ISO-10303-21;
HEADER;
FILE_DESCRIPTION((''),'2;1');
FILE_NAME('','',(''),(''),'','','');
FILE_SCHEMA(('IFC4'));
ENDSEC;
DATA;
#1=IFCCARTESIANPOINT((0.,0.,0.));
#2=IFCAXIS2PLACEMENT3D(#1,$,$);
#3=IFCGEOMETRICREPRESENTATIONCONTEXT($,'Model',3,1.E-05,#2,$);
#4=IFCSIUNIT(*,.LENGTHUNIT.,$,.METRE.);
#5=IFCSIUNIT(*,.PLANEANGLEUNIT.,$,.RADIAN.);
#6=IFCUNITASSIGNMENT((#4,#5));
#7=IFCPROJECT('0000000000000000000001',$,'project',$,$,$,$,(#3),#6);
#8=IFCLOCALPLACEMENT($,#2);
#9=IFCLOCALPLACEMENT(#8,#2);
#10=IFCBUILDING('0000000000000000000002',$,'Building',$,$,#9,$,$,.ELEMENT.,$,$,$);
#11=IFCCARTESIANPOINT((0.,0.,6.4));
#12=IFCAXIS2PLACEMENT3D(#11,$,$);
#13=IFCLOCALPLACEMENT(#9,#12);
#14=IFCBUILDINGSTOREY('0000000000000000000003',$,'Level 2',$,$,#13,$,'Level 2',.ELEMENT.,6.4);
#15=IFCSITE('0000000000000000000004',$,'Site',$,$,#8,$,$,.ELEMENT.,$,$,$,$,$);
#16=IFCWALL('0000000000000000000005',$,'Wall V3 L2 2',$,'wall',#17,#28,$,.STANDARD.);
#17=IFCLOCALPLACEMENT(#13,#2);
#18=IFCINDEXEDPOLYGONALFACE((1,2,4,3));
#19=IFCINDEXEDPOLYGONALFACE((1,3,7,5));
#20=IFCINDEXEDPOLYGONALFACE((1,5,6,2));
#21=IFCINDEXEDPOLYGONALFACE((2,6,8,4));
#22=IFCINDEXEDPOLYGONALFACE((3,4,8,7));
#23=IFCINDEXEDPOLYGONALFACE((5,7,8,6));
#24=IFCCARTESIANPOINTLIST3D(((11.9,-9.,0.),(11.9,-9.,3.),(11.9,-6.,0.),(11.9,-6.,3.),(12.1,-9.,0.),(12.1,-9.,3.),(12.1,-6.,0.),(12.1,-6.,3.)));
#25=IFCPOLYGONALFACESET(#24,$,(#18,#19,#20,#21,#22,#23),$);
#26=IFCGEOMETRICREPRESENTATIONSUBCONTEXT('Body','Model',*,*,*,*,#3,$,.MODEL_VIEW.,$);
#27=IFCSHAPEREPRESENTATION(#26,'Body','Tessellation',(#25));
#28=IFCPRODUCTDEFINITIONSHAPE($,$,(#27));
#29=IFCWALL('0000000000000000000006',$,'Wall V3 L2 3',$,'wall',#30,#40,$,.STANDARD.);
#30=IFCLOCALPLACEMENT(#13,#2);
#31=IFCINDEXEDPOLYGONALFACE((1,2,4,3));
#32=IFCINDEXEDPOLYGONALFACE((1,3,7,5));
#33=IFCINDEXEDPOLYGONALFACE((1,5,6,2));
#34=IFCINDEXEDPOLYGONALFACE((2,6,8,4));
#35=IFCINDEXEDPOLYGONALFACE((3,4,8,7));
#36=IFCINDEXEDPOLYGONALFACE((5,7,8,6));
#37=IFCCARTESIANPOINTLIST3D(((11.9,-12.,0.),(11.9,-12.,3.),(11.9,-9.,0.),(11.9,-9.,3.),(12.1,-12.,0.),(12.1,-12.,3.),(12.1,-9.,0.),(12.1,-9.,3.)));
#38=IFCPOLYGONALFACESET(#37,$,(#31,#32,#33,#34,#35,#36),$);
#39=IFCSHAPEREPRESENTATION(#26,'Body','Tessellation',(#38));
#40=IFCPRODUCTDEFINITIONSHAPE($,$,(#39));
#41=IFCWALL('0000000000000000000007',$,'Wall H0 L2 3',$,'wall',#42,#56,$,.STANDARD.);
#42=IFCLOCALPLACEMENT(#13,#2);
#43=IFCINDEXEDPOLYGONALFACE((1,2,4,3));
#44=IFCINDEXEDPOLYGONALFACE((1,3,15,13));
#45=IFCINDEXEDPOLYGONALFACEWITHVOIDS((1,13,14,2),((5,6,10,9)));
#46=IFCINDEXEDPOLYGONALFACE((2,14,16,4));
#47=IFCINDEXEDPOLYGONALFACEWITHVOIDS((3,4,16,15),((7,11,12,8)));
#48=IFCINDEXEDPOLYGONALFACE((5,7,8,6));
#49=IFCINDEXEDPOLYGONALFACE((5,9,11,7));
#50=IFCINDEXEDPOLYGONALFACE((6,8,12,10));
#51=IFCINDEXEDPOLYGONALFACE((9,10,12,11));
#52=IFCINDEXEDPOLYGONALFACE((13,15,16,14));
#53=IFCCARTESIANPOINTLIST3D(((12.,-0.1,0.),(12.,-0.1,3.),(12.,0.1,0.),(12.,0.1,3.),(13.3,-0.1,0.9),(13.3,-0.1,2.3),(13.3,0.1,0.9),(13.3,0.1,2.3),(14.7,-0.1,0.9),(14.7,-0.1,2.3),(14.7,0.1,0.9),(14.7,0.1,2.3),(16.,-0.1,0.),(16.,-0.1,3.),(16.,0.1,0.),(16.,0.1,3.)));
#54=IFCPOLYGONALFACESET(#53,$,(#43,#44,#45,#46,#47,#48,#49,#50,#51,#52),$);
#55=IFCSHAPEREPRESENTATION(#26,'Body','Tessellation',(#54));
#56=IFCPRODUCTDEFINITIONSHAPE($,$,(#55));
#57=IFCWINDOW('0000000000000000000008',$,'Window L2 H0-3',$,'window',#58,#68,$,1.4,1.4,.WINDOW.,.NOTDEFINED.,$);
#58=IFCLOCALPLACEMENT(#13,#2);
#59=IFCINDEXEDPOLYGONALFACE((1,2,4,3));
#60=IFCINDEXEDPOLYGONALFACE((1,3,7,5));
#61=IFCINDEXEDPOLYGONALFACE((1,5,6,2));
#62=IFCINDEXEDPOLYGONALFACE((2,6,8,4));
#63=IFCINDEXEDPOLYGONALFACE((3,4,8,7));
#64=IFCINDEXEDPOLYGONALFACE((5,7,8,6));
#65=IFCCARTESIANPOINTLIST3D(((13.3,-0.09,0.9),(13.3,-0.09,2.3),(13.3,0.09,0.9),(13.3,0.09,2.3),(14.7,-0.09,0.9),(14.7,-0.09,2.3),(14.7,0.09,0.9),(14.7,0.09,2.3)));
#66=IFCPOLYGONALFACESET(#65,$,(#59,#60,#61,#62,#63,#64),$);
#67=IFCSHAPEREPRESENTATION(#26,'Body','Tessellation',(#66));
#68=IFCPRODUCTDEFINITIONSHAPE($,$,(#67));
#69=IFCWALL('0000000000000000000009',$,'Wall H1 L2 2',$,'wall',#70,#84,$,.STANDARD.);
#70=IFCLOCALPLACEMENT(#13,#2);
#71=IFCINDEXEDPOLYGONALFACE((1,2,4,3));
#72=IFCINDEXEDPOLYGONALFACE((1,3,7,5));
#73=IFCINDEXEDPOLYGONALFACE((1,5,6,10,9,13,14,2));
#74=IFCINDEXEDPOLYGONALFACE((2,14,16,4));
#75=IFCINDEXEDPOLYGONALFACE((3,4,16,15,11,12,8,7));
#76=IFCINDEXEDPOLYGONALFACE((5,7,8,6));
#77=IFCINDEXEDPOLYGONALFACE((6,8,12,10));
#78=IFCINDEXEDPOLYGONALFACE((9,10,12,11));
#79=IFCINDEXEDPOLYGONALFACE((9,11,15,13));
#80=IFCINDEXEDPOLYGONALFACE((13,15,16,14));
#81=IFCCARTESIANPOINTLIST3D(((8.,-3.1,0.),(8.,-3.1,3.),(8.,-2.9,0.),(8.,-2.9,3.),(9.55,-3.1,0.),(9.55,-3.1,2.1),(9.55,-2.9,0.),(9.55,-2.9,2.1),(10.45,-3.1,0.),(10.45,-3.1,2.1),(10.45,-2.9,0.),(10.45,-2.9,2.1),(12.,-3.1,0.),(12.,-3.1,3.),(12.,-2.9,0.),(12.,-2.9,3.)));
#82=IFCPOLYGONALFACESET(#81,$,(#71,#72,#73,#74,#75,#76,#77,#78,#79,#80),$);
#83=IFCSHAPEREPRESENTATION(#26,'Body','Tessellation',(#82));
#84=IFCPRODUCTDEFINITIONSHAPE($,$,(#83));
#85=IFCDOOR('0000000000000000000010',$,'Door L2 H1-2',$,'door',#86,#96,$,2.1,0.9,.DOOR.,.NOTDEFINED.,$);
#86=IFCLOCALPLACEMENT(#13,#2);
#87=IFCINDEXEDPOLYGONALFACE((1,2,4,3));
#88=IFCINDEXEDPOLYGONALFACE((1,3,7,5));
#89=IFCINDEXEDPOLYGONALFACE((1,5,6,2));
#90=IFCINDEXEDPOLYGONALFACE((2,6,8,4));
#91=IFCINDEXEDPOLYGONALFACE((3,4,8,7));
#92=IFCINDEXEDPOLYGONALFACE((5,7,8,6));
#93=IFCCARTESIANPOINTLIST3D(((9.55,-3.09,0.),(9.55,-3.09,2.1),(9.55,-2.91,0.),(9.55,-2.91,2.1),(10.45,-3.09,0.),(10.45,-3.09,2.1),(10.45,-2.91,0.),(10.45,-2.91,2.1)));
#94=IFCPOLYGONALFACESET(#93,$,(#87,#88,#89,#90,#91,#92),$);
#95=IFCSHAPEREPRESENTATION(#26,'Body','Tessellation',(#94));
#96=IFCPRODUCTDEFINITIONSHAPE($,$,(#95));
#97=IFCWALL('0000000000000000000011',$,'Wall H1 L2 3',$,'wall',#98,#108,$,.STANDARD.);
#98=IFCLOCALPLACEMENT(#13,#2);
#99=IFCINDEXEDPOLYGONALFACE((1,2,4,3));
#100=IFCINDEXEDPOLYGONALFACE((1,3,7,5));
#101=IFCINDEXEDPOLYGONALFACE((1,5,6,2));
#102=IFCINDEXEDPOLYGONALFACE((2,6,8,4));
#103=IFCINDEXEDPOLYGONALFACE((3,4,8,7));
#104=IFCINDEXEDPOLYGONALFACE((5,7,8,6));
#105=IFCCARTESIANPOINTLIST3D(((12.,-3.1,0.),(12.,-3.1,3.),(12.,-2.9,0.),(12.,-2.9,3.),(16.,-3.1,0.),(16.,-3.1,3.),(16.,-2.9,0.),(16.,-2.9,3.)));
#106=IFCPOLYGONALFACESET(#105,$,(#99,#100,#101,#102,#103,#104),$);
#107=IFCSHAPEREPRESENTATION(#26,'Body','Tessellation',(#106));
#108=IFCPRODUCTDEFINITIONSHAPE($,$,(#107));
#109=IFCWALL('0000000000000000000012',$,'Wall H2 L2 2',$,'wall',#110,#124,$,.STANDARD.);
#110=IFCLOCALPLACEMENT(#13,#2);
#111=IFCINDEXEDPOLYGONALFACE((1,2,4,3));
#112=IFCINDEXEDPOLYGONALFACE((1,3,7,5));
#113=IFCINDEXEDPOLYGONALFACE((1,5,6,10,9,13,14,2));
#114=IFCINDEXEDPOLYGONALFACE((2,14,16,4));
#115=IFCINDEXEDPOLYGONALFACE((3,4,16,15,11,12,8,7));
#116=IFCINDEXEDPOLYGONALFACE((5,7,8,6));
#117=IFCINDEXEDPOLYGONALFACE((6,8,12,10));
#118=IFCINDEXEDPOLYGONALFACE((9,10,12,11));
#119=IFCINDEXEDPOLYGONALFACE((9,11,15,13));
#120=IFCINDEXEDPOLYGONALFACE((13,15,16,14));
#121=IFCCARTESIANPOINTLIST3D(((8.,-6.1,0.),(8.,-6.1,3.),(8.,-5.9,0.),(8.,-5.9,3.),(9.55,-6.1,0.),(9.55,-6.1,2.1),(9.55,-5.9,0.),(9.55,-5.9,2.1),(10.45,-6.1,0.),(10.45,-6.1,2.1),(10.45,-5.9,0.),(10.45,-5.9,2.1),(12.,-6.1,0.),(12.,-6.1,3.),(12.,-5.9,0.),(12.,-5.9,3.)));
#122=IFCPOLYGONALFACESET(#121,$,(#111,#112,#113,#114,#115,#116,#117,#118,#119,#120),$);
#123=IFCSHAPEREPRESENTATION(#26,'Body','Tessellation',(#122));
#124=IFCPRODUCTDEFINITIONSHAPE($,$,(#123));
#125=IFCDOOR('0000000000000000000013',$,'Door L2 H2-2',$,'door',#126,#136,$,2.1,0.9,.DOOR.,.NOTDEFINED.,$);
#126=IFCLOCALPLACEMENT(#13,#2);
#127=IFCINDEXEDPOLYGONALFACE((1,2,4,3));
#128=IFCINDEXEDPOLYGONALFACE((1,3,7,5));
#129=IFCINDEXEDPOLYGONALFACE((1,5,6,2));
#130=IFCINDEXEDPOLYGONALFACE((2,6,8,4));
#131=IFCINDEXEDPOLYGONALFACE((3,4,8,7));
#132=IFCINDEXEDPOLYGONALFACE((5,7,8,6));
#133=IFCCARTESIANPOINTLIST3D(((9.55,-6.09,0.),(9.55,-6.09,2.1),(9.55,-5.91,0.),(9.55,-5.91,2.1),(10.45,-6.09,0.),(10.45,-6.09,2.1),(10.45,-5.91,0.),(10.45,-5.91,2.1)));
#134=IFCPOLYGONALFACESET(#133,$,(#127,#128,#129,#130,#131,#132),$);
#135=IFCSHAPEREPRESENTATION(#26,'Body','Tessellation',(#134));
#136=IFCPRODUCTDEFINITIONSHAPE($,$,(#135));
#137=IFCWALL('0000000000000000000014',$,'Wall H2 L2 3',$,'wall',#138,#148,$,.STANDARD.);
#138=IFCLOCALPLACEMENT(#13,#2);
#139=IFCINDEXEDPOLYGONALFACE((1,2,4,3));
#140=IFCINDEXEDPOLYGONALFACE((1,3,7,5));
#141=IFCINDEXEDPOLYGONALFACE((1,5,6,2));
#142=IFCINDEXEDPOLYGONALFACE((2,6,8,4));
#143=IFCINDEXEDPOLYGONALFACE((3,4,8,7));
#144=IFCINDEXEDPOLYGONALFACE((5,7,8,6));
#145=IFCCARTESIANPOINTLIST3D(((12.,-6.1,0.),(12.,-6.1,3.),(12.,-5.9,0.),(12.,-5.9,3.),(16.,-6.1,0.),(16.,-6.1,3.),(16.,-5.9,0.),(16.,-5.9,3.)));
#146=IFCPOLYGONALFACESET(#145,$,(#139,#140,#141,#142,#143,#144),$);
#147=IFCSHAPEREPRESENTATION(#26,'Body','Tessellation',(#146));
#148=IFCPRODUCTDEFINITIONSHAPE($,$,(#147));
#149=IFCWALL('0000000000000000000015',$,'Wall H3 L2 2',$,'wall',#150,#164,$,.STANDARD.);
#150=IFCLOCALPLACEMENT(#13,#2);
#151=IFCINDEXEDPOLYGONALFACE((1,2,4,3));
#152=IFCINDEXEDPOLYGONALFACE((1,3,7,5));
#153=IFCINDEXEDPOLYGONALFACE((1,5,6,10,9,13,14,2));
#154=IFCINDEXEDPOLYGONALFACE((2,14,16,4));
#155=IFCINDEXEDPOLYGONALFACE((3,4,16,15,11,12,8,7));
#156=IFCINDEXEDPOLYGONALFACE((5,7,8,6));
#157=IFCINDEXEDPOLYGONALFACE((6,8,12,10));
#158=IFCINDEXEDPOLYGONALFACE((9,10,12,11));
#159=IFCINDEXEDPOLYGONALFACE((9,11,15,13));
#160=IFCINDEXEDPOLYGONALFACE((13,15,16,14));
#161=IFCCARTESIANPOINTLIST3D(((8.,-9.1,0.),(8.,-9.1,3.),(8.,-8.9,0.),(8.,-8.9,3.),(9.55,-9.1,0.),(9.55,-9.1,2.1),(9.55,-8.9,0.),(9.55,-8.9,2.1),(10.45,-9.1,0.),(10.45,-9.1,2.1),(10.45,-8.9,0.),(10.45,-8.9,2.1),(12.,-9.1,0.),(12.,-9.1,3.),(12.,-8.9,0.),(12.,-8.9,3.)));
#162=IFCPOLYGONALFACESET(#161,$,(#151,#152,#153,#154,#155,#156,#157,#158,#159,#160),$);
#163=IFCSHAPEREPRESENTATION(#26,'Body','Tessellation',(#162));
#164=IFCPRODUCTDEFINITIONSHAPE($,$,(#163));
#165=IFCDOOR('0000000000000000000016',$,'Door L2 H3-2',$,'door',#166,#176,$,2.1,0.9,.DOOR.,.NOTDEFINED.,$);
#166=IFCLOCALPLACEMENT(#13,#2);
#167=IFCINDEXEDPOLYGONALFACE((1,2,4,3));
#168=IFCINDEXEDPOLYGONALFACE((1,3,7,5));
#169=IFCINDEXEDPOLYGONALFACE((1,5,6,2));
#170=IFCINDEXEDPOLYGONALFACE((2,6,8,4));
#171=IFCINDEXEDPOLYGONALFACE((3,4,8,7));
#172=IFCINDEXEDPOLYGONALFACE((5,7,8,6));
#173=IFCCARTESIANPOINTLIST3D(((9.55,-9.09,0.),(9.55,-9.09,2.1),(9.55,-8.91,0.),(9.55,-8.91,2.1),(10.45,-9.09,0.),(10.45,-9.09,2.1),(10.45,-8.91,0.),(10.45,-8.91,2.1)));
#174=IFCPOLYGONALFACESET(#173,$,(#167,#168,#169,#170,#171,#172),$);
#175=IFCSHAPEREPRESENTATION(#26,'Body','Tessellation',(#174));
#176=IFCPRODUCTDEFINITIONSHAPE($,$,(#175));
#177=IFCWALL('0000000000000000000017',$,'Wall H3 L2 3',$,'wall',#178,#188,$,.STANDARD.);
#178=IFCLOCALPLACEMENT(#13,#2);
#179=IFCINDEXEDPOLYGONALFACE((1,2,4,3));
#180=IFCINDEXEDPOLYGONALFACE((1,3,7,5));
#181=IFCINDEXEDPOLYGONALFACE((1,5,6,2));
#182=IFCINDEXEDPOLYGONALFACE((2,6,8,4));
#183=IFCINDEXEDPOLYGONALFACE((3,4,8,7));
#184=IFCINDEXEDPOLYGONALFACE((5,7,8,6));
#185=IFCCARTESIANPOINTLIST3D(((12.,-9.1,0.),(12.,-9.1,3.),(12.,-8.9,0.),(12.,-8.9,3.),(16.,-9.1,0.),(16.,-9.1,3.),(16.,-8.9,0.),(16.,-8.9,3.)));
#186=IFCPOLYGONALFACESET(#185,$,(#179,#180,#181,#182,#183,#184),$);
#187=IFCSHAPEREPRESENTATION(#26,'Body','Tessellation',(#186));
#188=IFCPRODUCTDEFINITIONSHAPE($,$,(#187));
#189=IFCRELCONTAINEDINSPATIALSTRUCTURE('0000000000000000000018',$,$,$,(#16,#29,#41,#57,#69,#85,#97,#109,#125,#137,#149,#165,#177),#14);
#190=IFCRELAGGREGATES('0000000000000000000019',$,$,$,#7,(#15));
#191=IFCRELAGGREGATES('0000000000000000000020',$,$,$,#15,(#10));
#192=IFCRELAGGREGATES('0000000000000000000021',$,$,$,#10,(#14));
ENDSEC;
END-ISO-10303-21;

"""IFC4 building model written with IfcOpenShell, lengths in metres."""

from ifc_helpers import new_model, si_unit, frame, frame_2d, origin, origin_2d, place, context, subcontext, project, spatial, rectangle, extrude, element, fill, save


model = new_model("IFC4")

# Units and contexts
model_context = context("Model", 3, precision=1e-05, world=origin())
body_context = subcontext(model_context, "Body", "Model", "MODEL_VIEW")
ifc_project = project(units=[si_unit("LENGTHUNIT", "METRE"), si_unit("PLANEANGLEUNIT", "RADIAN")], contexts=[model_context])

# Site, building, storey
site_placement = place(None, origin())
site = spatial("IfcSite", under=ifc_project, at=site_placement, Name="Site", CompositionType="ELEMENT")
building_placement = place(site_placement, origin())
building = spatial("IfcBuilding", under=site, at=building_placement, Name="Building", CompositionType="ELEMENT")
storey_placement = place(building_placement, frame((0.0, 0.0, 6.4)))
storey = spatial("IfcBuildingStorey", under=building, at=storey_placement, Name="Level 2", LongName="Level 2", CompositionType="ELEMENT", Elevation=6.4)

# Walls
for number, where, z_axis, x_axis, name in (
    (1, (12.0, -6.0, 0.0), (0.0, 0.0, 1.0), (0.0, -1.0, 0.0), "Wall V3 L2 2"),
    (2, (12.0, -9.0, 0.0), (0.0, 0.0, 1.0), (0.0, -1.0, 0.0), "Wall V3 L2 3"),
):
    element("IfcWall", number, at=place(storey_placement, frame(where, z_axis=z_axis, x_axis=x_axis)), inside=storey, Name=name, ObjectType="wall", PredefinedType="STANDARD", context=body_context, shape_type="SweptSolid", body=[
        extrude(rectangle(XDim=3.0, YDim=0.2, at=frame_2d((1.5, 0.0))), origin(), (0.0, 0.0, 1.0), 3.0),
    ])

# Wall, opening, window
wall_1_placement = place(storey_placement, frame((12.0, 0.0, 0.0), z_axis=(0.0, 0.0, 1.0), x_axis=(1.0, 0.0, 0.0)))
wall_1 = element("IfcWall", 3, at=wall_1_placement, inside=storey, Name="Wall H0 L2 3", ObjectType="wall", PredefinedType="STANDARD", context=body_context, shape_type="SweptSolid", body=[
    extrude(rectangle(XDim=4.0, YDim=0.2, at=frame_2d((2.0, 0.0))), origin(), (0.0, 0.0, 1.0), 3.0),
])
opening_1_placement = place(storey_placement, frame((14.0, 0.0, 0.9), z_axis=(0.0, 0.0, 1.0), x_axis=(1.0, 0.0, 0.0)))
opening_1 = element("IfcOpeningElement", 4, at=opening_1_placement, cuts=wall_1, ObjectType="Opening", PredefinedType="OPENING", context=body_context, shape_type="SweptSolid", body=[
    extrude(rectangle(XDim=1.4, YDim=0.22, at=origin_2d()), origin(), (0.0, 0.0, 1.0), 1.4),
])
window_1_placement = place(storey_placement, frame((14.0, 0.0, 0.9), z_axis=(0.0, 0.0, 1.0), x_axis=(1.0, 0.0, 0.0)))
window_1 = element("IfcWindow", 5, at=window_1_placement, inside=storey, Name="Window L2 H0-3", ObjectType="window", OverallHeight=1.4, OverallWidth=1.4, PartitioningType="NOTDEFINED", PredefinedType="WINDOW", context=body_context, shape_type="SweptSolid", body=[
    extrude(rectangle(XDim=1.4, YDim=0.18, at=origin_2d()), origin(), (0.0, 0.0, 1.0), 1.4),
])
fill(opening_1, window_1)

# Wall, opening, door
wall_2_placement = place(storey_placement, frame((8.0, -3.0, 0.0), z_axis=(0.0, 0.0, 1.0), x_axis=(1.0, 0.0, 0.0)))
wall_2 = element("IfcWall", 6, at=wall_2_placement, inside=storey, Name="Wall H1 L2 2", ObjectType="wall", PredefinedType="STANDARD", context=body_context, shape_type="SweptSolid", body=[
    extrude(rectangle(XDim=4.0, YDim=0.2, at=frame_2d((2.0, 0.0))), origin(), (0.0, 0.0, 1.0), 3.0),
])
opening_2_placement = place(storey_placement, frame((10.0, -3.0, 0.0), z_axis=(0.0, 0.0, 1.0), x_axis=(1.0, 0.0, 0.0)))
opening_2 = element("IfcOpeningElement", 7, at=opening_2_placement, cuts=wall_2, ObjectType="Opening", PredefinedType="OPENING", context=body_context, shape_type="SweptSolid", body=[
    extrude(rectangle(XDim=0.9, YDim=0.22, at=origin_2d()), origin(), (0.0, 0.0, 1.0), 2.1),
])
door_1_placement = place(storey_placement, frame((10.0, -3.0, 0.0), z_axis=(0.0, 0.0, 1.0), x_axis=(1.0, 0.0, 0.0)))
door_1 = element("IfcDoor", 8, at=door_1_placement, inside=storey, Name="Door L2 H1-2", ObjectType="door", OperationType="NOTDEFINED", OverallHeight=2.1, OverallWidth=0.9, PredefinedType="DOOR", context=body_context, shape_type="SweptSolid", body=[
    extrude(rectangle(XDim=0.9, YDim=0.18, at=origin_2d()), origin(), (0.0, 0.0, 1.0), 2.1),
])
fill(opening_2, door_1)

# Wall
wall_3_placement = place(storey_placement, frame((12.0, -3.0, 0.0), z_axis=(0.0, 0.0, 1.0), x_axis=(1.0, 0.0, 0.0)))
element("IfcWall", 9, at=wall_3_placement, inside=storey, Name="Wall H1 L2 3", ObjectType="wall", PredefinedType="STANDARD", context=body_context, shape_type="SweptSolid", body=[
    extrude(rectangle(XDim=4.0, YDim=0.2, at=frame_2d((2.0, 0.0))), origin(), (0.0, 0.0, 1.0), 3.0),
])

# Wall, opening, door
wall_4_placement = place(storey_placement, frame((8.0, -6.0, 0.0), z_axis=(0.0, 0.0, 1.0), x_axis=(1.0, 0.0, 0.0)))
wall_4 = element("IfcWall", 10, at=wall_4_placement, inside=storey, Name="Wall H2 L2 2", ObjectType="wall", PredefinedType="STANDARD", context=body_context, shape_type="SweptSolid", body=[
    extrude(rectangle(XDim=4.0, YDim=0.2, at=frame_2d((2.0, 0.0))), origin(), (0.0, 0.0, 1.0), 3.0),
])
opening_3_placement = place(storey_placement, frame((10.0, -6.0, 0.0), z_axis=(0.0, 0.0, 1.0), x_axis=(1.0, 0.0, 0.0)))
opening_3 = element("IfcOpeningElement", 11, at=opening_3_placement, cuts=wall_4, ObjectType="Opening", PredefinedType="OPENING", context=body_context, shape_type="SweptSolid", body=[
    extrude(rectangle(XDim=0.9, YDim=0.22, at=origin_2d()), origin(), (0.0, 0.0, 1.0), 2.1),
])
door_2_placement = place(storey_placement, frame((10.0, -6.0, 0.0), z_axis=(0.0, 0.0, 1.0), x_axis=(1.0, 0.0, 0.0)))
door_2 = element("IfcDoor", 12, at=door_2_placement, inside=storey, Name="Door L2 H2-2", ObjectType="door", OperationType="NOTDEFINED", OverallHeight=2.1, OverallWidth=0.9, PredefinedType="DOOR", context=body_context, shape_type="SweptSolid", body=[
    extrude(rectangle(XDim=0.9, YDim=0.18, at=origin_2d()), origin(), (0.0, 0.0, 1.0), 2.1),
])
fill(opening_3, door_2)

# Wall
wall_5_placement = place(storey_placement, frame((12.0, -6.0, 0.0), z_axis=(0.0, 0.0, 1.0), x_axis=(1.0, 0.0, 0.0)))
element("IfcWall", 13, at=wall_5_placement, inside=storey, Name="Wall H2 L2 3", ObjectType="wall", PredefinedType="STANDARD", context=body_context, shape_type="SweptSolid", body=[
    extrude(rectangle(XDim=4.0, YDim=0.2, at=frame_2d((2.0, 0.0))), origin(), (0.0, 0.0, 1.0), 3.0),
])

# Wall, opening, door
wall_6_placement = place(storey_placement, frame((8.0, -9.0, 0.0), z_axis=(0.0, 0.0, 1.0), x_axis=(1.0, 0.0, 0.0)))
wall_6 = element("IfcWall", 14, at=wall_6_placement, inside=storey, Name="Wall H3 L2 2", ObjectType="wall", PredefinedType="STANDARD", context=body_context, shape_type="SweptSolid", body=[
    extrude(rectangle(XDim=4.0, YDim=0.2, at=frame_2d((2.0, 0.0))), origin(), (0.0, 0.0, 1.0), 3.0),
])
opening_4_placement = place(storey_placement, frame((10.0, -9.0, 0.0), z_axis=(0.0, 0.0, 1.0), x_axis=(1.0, 0.0, 0.0)))
opening_4 = element("IfcOpeningElement", 15, at=opening_4_placement, cuts=wall_6, ObjectType="Opening", PredefinedType="OPENING", context=body_context, shape_type="SweptSolid", body=[
    extrude(rectangle(XDim=0.9, YDim=0.22, at=origin_2d()), origin(), (0.0, 0.0, 1.0), 2.1),
])
door_3_placement = place(storey_placement, frame((10.0, -9.0, 0.0), z_axis=(0.0, 0.0, 1.0), x_axis=(1.0, 0.0, 0.0)))
door_3 = element("IfcDoor", 16, at=door_3_placement, inside=storey, Name="Door L2 H3-2", ObjectType="door", OperationType="NOTDEFINED", OverallHeight=2.1, OverallWidth=0.9, PredefinedType="DOOR", context=body_context, shape_type="SweptSolid", body=[
    extrude(rectangle(XDim=0.9, YDim=0.18, at=origin_2d()), origin(), (0.0, 0.0, 1.0), 2.1),
])
fill(opening_4, door_3)

# Wall
for number, where, z_axis, x_axis, name in (
    (17, (12.0, -9.0, 0.0), (0.0, 0.0, 1.0), (1.0, 0.0, 0.0), "Wall H3 L2 3"),
):
    element("IfcWall", number, at=place(storey_placement, frame(where, z_axis=z_axis, x_axis=x_axis)), inside=storey, Name=name, ObjectType="wall", PredefinedType="STANDARD", context=body_context, shape_type="SweptSolid", body=[
        extrude(rectangle(XDim=4.0, YDim=0.2, at=frame_2d((2.0, 0.0))), origin(), (0.0, 0.0, 1.0), 3.0),
    ])

save(model, "model.ifc")
